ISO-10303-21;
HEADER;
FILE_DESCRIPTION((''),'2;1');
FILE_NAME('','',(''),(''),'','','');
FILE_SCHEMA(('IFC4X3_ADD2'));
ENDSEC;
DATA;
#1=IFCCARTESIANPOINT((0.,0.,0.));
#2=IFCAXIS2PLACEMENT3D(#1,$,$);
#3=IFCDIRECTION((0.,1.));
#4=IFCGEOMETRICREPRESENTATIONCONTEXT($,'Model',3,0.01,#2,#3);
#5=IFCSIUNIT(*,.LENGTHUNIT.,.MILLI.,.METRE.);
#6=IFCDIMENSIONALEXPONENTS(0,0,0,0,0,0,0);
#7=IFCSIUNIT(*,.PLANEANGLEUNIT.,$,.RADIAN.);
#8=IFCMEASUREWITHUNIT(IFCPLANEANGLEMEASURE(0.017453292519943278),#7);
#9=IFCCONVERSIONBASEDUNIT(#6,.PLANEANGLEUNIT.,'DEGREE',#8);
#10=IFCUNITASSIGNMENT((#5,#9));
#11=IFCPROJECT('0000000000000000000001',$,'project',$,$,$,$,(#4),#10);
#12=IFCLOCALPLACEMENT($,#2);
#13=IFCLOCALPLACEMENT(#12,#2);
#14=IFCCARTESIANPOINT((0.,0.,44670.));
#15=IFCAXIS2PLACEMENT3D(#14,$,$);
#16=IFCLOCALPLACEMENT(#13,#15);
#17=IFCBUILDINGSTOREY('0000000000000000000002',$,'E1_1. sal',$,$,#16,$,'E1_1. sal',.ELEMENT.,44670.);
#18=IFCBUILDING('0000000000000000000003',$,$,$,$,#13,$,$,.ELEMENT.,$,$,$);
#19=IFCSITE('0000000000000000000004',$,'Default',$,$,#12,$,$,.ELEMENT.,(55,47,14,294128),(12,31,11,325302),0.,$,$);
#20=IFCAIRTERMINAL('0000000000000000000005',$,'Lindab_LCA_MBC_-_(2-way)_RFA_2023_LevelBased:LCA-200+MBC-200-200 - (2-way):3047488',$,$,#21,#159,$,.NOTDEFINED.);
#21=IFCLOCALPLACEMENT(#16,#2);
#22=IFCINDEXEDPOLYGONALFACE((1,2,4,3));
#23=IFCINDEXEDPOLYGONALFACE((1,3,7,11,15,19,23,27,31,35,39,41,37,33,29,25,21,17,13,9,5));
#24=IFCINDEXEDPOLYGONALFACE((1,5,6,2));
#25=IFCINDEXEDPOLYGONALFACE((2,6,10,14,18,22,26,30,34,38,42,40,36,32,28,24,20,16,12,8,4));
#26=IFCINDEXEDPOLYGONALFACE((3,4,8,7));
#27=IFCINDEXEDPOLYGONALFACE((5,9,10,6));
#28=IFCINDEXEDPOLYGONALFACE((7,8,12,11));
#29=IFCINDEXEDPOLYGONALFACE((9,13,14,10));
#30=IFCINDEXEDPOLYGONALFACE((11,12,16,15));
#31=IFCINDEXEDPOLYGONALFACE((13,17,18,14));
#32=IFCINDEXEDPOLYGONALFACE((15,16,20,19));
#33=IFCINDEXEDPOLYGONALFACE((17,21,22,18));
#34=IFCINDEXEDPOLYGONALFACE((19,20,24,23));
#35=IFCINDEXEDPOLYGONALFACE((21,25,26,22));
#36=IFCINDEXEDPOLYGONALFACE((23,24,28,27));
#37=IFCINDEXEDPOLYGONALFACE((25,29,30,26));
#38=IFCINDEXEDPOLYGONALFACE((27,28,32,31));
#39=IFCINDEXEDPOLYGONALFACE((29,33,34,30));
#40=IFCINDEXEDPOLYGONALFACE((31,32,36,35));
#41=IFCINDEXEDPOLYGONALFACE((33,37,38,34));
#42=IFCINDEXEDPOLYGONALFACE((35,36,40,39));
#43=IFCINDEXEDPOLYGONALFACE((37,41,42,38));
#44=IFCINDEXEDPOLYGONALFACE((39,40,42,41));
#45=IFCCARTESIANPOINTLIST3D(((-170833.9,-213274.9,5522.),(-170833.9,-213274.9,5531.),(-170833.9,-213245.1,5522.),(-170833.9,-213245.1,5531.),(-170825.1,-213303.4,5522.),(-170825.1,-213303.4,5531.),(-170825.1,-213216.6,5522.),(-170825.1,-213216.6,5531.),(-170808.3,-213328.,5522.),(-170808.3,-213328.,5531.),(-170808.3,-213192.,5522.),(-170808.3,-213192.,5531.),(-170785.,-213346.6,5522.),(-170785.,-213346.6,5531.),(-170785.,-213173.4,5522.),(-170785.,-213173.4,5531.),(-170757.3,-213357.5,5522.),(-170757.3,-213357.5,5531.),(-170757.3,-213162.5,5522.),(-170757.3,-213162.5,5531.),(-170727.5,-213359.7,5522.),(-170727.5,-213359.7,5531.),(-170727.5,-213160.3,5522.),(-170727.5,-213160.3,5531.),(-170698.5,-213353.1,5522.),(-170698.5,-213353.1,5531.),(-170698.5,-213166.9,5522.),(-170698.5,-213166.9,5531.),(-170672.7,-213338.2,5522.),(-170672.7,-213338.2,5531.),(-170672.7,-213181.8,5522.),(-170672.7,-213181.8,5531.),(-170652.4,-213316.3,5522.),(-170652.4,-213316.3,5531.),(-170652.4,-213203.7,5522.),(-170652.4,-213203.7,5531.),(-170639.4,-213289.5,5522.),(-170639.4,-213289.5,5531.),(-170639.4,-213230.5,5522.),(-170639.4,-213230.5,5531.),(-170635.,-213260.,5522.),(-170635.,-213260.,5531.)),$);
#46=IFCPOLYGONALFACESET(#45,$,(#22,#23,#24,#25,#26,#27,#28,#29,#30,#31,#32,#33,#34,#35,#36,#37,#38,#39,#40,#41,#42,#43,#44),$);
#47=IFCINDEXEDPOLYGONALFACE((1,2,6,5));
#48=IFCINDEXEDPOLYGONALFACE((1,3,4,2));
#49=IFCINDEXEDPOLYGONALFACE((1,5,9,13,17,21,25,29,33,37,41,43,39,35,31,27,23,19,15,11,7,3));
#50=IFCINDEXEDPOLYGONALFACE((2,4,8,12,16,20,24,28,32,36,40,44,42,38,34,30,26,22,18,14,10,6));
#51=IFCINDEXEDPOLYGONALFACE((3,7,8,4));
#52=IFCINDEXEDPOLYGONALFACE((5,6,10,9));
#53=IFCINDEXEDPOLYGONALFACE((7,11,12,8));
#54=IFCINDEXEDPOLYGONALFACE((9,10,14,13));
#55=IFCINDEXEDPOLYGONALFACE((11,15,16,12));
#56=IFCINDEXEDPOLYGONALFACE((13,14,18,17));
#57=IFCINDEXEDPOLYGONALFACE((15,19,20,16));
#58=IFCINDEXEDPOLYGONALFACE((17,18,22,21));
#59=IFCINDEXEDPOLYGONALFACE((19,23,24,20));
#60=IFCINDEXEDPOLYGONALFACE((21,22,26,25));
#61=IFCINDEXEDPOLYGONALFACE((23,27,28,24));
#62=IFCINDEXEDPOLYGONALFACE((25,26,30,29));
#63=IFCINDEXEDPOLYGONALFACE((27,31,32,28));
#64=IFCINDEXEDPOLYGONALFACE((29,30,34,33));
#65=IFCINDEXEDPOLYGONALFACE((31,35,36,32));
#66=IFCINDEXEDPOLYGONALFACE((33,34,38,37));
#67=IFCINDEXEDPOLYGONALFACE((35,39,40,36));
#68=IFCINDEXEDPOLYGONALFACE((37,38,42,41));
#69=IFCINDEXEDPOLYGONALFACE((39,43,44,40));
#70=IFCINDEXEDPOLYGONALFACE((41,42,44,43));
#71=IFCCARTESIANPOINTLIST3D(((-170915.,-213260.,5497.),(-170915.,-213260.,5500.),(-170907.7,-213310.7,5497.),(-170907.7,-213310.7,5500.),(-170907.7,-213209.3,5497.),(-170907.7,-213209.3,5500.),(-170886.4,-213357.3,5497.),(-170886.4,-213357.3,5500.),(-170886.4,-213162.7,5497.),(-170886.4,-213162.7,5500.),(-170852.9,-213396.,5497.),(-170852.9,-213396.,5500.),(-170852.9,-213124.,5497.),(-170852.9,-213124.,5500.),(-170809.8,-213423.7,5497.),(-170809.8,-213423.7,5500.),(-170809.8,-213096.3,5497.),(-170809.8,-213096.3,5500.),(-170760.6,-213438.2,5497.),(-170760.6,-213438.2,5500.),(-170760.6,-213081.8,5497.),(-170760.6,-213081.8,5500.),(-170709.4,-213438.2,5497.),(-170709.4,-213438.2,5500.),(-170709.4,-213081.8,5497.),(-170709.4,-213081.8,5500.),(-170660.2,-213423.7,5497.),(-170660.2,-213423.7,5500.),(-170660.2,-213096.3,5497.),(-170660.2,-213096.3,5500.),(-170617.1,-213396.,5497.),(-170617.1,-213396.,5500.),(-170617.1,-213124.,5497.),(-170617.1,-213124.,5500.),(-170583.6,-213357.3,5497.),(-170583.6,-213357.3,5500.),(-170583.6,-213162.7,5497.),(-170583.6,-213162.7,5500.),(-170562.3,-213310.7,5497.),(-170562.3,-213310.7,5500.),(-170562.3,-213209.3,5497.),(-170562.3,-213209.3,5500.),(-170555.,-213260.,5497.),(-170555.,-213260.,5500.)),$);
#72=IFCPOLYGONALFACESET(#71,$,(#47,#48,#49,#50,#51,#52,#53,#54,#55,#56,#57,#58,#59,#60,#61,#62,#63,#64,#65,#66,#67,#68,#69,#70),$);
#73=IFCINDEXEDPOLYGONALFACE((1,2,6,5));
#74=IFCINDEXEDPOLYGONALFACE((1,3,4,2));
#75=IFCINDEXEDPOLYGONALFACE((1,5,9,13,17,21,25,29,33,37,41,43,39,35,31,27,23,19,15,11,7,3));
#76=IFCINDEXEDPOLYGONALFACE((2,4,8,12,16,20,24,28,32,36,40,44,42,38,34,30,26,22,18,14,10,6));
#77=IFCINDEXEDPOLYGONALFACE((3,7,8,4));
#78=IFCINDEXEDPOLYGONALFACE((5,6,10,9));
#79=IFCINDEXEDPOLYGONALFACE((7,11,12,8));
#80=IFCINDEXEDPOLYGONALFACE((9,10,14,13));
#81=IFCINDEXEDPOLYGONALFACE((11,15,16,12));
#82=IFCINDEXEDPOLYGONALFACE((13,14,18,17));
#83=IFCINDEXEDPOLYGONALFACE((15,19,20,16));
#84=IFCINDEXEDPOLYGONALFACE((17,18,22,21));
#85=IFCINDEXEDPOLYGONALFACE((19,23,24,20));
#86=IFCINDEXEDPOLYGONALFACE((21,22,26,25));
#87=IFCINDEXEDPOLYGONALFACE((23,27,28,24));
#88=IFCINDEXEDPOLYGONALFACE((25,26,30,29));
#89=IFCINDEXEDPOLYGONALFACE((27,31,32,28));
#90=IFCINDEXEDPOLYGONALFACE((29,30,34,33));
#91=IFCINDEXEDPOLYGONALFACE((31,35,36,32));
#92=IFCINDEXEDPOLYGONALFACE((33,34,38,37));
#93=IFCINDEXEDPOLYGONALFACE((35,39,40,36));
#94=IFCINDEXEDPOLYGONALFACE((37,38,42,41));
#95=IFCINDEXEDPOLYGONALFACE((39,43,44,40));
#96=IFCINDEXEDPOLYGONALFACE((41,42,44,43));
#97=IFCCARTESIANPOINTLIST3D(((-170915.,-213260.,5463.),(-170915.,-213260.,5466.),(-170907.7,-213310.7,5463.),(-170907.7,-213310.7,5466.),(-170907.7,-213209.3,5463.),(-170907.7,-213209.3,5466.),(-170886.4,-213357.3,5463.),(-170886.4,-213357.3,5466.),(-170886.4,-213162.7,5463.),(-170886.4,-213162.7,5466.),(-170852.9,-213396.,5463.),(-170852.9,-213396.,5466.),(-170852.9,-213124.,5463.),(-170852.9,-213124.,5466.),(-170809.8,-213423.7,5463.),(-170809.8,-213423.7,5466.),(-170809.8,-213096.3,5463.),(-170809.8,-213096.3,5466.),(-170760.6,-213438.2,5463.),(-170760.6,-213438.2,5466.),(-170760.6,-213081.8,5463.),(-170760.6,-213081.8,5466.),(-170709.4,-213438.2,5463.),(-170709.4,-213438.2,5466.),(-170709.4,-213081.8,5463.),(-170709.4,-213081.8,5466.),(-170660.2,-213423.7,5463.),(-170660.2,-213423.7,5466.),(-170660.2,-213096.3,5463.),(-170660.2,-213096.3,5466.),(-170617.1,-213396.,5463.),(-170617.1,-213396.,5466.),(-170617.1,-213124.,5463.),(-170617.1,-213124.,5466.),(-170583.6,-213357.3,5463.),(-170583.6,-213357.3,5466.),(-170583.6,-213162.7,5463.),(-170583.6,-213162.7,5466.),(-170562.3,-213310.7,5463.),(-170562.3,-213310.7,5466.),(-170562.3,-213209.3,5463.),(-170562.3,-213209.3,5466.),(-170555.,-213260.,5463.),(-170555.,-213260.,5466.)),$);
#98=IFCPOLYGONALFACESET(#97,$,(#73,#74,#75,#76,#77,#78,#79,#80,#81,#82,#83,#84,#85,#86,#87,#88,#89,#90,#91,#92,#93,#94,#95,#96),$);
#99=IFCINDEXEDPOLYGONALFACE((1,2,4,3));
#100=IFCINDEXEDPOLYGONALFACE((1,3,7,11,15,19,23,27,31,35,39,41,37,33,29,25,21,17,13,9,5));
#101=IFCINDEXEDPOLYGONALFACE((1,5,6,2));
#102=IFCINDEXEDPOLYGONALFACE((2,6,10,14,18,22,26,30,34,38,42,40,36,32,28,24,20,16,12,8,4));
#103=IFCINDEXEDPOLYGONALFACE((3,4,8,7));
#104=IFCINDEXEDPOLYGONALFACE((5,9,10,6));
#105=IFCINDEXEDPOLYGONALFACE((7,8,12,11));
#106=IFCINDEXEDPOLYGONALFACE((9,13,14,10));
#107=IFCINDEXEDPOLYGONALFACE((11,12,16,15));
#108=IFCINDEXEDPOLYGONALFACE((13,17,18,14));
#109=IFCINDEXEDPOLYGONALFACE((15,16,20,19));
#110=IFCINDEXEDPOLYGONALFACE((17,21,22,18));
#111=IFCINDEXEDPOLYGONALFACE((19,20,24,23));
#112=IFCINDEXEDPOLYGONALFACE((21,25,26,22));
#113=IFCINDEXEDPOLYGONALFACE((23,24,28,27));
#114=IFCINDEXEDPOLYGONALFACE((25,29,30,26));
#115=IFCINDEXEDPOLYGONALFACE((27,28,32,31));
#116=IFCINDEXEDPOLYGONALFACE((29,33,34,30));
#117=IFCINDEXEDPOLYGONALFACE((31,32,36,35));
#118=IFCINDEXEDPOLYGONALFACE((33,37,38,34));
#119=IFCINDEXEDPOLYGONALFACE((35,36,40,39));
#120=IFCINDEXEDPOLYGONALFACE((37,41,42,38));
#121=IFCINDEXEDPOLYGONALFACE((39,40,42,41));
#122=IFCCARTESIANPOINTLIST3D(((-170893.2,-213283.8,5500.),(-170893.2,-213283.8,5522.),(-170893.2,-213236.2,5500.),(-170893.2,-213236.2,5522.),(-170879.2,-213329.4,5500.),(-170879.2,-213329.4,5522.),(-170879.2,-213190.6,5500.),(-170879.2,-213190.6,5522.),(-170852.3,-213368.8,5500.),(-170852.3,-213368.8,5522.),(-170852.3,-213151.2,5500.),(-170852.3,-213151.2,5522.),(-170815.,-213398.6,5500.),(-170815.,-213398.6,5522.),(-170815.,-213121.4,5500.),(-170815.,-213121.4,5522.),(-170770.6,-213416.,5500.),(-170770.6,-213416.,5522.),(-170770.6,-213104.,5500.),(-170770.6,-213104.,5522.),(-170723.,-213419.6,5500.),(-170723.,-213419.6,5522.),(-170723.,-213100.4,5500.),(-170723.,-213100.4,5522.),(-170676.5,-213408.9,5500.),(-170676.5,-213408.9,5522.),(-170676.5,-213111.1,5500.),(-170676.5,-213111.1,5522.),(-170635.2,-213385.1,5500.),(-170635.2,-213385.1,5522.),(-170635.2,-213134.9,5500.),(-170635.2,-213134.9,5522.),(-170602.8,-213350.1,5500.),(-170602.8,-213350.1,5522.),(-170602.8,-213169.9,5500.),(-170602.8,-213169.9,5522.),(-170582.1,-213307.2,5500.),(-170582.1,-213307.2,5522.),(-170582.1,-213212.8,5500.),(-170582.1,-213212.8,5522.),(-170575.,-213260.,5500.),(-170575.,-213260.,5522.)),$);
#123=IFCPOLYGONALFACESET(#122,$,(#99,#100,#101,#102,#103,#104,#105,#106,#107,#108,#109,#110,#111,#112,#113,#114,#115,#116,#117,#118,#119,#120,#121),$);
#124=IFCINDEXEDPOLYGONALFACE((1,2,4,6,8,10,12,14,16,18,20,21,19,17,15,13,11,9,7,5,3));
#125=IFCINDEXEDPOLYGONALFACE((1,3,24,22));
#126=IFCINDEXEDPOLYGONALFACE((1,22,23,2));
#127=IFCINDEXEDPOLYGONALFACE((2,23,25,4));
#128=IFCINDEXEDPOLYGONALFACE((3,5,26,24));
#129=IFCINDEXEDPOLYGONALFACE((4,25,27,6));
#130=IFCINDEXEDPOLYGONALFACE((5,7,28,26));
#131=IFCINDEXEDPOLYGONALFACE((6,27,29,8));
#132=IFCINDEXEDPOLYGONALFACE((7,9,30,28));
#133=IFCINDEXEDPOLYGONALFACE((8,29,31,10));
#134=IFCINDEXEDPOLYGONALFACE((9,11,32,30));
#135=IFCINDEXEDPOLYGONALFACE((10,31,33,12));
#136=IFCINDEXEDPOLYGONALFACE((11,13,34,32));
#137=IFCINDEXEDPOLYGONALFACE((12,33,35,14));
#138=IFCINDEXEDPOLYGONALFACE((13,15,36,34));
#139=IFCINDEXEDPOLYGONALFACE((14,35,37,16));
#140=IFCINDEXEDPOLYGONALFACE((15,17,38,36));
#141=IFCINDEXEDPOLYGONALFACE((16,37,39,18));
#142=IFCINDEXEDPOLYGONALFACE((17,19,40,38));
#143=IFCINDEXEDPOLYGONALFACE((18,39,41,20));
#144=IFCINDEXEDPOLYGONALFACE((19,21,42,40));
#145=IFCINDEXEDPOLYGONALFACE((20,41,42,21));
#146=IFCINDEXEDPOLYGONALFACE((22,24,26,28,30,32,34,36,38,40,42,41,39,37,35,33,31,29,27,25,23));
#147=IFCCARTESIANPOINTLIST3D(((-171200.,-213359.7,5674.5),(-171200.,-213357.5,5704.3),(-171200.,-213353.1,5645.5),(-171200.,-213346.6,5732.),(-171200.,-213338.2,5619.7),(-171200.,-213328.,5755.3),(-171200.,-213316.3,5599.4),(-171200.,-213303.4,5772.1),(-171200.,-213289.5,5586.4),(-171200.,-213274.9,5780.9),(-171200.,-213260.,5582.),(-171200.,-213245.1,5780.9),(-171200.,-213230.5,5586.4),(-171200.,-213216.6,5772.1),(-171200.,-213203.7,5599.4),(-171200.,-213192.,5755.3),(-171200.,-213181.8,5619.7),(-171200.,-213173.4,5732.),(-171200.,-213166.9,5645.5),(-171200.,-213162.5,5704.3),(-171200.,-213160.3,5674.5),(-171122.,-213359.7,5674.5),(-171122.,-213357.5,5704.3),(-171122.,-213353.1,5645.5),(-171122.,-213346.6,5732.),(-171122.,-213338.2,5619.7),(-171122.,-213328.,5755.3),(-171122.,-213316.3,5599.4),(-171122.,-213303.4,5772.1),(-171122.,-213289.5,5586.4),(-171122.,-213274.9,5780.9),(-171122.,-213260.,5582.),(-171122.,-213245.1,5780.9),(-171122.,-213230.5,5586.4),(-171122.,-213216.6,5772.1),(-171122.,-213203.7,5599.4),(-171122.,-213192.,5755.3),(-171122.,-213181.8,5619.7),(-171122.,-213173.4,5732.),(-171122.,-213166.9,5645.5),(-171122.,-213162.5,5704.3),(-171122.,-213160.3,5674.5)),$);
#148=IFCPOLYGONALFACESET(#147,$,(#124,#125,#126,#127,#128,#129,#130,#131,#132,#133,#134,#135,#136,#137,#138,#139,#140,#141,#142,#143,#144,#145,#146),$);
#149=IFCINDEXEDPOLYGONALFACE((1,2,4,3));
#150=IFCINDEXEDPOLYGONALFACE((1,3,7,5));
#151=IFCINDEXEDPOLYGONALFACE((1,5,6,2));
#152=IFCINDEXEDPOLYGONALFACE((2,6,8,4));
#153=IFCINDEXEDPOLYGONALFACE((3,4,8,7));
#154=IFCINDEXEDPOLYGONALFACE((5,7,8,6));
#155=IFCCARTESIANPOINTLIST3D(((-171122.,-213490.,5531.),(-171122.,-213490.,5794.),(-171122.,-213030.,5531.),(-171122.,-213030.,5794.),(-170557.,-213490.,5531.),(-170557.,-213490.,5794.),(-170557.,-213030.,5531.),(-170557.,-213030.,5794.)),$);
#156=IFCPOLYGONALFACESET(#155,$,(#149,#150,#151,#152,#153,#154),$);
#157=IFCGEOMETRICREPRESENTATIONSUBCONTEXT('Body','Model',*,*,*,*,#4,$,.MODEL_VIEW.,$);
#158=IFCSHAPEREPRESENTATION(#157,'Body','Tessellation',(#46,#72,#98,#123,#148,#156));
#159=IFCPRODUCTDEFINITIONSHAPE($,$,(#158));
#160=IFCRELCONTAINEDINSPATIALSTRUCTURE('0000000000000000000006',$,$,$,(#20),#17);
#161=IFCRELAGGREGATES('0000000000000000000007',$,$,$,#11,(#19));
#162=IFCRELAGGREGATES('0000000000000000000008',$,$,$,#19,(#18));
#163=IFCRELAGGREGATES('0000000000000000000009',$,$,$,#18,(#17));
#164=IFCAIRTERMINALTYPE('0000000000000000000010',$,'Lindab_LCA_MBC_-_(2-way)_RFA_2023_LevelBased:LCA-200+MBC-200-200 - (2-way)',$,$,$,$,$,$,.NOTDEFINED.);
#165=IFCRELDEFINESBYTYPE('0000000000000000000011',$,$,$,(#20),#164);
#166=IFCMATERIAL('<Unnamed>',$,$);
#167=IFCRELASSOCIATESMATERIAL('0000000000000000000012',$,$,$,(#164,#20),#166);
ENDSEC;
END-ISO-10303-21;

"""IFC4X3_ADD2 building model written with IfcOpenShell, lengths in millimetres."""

from ifc_helpers import new_model, entity, si_unit, converted_unit, direction, frame, frame_2d, origin, origin_2d_with_axis, place, context, subcontext, project, spatial, rectangle, circle, extrude, source, transform, mapped, material, type_object, type_shapes, element, save


model = new_model("IFC4X3_ADD2")

# Units and contexts
model_context = context("Model", 3, precision=0.01, world=origin(), true_north=direction((0.0, 1.0)))
body_context = subcontext(model_context, "Body", "Model", "MODEL_VIEW")
ifc_project = project(units=[si_unit("LENGTHUNIT", "METRE", prefix="MILLI"), converted_unit("PLANEANGLEUNIT", "DEGREE", entity("IfcPlaneAngleMeasure", 0.017453292519943278), si_unit("PLANEANGLEUNIT", "RADIAN"), dimensions=[0, 0, 0, 0, 0, 0, 0])], contexts=[model_context])

# Site, building, storey
site_placement = place(None, origin())
site = spatial("IfcSite", under=ifc_project, at=site_placement, Name="Default", CompositionType="ELEMENT", RefLatitude=(55, 47, 14, 294128), RefLongitude=(12, 31, 11, 325302), RefElevation=0.0)
building_placement = place(site_placement, origin())
building = spatial("IfcBuilding", under=site, at=building_placement, CompositionType="ELEMENT")
storey_placement = place(building_placement, frame((0.0, 0.0, 44670.0)))
storey = spatial("IfcBuildingStorey", under=building, at=storey_placement, Name="E1_1. sal", LongName="E1_1. sal", CompositionType="ELEMENT", Elevation=44670.0)

# Air terminal
ifc_material_1 = material(Name="<Unnamed>")
air_terminal_type_1 = type_object("IfcAirTerminalType", Name="Lindab_LCA_MBC_-_(2-way)_RFA_2023_LevelBased:LCA-200+MBC-200-200 - (2-way)", PredefinedType="NOTDEFINED", material=ifc_material_1)
shared_shape_1 = source(origin(), body_context, "Body", "SweptSolid", [
    extrude(circle(Radius=100.0, at=frame_2d((0.0, 0.0), x_axis=(1.0, 0.0))), frame((0.0, 0.0, 22.0)), (0.0, 0.0, 1.0), 9.0),
    extrude(circle(Radius=180.0, at=frame_2d((0.0, 0.0), x_axis=(1.0, 0.0))), frame((0.0, 0.0, -3.0)), (0.0, 0.0, 1.0), 3.0),
    extrude(circle(Radius=180.0, at=frame_2d((0.0, 0.0), x_axis=(1.0, 0.0))), frame((0.0, 0.0, -37.0)), (0.0, 0.0, 1.0), 3.0),
    extrude(circle(Radius=160.0, at=frame_2d((0.0, 0.0), x_axis=(1.0, 0.0))), origin(), (0.0, 0.0, 1.0), 22.0),
    extrude(circle(Radius=100.0, at=frame_2d((0.0, 0.0), x_axis=(1.0, 0.0))), frame((-465.0, 0.0, 182.0), z_axis=(1.0, 0.0, 0.0), x_axis=(0.0, 0.0, -1.0)), (0.0, 0.0, 1.0), 78.0),
    extrude(rectangle(XDim=460.0, YDim=565.0, at=origin_2d_with_axis()), frame((-104.5, 0.0, 31.0), z_axis=(0.0, 0.0, 1.0), x_axis=(0.0, -1.0, 0.0)), (0.0, 0.0, 1.0), 263.0),
])
type_shapes(air_terminal_type_1, [shared_shape_1])
for number, where, name in (
    (1, (-170735.0, -213260.0, 5500.0), "Lindab_LCA_MBC_-_(2-way)_RFA_2023_LevelBased:LCA-200+MBC-200-200 - (2-way):3047488"),
):
    element("IfcAirTerminal", number, at=place(storey_placement, frame(where)), inside=storey, type_object=air_terminal_type_1, material=ifc_material_1, Name=name, PredefinedType="NOTDEFINED", context=body_context, shape_type="MappedRepresentation", body=[
        mapped(shared_shape_1, transform((0.0, 0.0, 0.0), scale=1.0)),
    ])

save(model, "model.ifc")
